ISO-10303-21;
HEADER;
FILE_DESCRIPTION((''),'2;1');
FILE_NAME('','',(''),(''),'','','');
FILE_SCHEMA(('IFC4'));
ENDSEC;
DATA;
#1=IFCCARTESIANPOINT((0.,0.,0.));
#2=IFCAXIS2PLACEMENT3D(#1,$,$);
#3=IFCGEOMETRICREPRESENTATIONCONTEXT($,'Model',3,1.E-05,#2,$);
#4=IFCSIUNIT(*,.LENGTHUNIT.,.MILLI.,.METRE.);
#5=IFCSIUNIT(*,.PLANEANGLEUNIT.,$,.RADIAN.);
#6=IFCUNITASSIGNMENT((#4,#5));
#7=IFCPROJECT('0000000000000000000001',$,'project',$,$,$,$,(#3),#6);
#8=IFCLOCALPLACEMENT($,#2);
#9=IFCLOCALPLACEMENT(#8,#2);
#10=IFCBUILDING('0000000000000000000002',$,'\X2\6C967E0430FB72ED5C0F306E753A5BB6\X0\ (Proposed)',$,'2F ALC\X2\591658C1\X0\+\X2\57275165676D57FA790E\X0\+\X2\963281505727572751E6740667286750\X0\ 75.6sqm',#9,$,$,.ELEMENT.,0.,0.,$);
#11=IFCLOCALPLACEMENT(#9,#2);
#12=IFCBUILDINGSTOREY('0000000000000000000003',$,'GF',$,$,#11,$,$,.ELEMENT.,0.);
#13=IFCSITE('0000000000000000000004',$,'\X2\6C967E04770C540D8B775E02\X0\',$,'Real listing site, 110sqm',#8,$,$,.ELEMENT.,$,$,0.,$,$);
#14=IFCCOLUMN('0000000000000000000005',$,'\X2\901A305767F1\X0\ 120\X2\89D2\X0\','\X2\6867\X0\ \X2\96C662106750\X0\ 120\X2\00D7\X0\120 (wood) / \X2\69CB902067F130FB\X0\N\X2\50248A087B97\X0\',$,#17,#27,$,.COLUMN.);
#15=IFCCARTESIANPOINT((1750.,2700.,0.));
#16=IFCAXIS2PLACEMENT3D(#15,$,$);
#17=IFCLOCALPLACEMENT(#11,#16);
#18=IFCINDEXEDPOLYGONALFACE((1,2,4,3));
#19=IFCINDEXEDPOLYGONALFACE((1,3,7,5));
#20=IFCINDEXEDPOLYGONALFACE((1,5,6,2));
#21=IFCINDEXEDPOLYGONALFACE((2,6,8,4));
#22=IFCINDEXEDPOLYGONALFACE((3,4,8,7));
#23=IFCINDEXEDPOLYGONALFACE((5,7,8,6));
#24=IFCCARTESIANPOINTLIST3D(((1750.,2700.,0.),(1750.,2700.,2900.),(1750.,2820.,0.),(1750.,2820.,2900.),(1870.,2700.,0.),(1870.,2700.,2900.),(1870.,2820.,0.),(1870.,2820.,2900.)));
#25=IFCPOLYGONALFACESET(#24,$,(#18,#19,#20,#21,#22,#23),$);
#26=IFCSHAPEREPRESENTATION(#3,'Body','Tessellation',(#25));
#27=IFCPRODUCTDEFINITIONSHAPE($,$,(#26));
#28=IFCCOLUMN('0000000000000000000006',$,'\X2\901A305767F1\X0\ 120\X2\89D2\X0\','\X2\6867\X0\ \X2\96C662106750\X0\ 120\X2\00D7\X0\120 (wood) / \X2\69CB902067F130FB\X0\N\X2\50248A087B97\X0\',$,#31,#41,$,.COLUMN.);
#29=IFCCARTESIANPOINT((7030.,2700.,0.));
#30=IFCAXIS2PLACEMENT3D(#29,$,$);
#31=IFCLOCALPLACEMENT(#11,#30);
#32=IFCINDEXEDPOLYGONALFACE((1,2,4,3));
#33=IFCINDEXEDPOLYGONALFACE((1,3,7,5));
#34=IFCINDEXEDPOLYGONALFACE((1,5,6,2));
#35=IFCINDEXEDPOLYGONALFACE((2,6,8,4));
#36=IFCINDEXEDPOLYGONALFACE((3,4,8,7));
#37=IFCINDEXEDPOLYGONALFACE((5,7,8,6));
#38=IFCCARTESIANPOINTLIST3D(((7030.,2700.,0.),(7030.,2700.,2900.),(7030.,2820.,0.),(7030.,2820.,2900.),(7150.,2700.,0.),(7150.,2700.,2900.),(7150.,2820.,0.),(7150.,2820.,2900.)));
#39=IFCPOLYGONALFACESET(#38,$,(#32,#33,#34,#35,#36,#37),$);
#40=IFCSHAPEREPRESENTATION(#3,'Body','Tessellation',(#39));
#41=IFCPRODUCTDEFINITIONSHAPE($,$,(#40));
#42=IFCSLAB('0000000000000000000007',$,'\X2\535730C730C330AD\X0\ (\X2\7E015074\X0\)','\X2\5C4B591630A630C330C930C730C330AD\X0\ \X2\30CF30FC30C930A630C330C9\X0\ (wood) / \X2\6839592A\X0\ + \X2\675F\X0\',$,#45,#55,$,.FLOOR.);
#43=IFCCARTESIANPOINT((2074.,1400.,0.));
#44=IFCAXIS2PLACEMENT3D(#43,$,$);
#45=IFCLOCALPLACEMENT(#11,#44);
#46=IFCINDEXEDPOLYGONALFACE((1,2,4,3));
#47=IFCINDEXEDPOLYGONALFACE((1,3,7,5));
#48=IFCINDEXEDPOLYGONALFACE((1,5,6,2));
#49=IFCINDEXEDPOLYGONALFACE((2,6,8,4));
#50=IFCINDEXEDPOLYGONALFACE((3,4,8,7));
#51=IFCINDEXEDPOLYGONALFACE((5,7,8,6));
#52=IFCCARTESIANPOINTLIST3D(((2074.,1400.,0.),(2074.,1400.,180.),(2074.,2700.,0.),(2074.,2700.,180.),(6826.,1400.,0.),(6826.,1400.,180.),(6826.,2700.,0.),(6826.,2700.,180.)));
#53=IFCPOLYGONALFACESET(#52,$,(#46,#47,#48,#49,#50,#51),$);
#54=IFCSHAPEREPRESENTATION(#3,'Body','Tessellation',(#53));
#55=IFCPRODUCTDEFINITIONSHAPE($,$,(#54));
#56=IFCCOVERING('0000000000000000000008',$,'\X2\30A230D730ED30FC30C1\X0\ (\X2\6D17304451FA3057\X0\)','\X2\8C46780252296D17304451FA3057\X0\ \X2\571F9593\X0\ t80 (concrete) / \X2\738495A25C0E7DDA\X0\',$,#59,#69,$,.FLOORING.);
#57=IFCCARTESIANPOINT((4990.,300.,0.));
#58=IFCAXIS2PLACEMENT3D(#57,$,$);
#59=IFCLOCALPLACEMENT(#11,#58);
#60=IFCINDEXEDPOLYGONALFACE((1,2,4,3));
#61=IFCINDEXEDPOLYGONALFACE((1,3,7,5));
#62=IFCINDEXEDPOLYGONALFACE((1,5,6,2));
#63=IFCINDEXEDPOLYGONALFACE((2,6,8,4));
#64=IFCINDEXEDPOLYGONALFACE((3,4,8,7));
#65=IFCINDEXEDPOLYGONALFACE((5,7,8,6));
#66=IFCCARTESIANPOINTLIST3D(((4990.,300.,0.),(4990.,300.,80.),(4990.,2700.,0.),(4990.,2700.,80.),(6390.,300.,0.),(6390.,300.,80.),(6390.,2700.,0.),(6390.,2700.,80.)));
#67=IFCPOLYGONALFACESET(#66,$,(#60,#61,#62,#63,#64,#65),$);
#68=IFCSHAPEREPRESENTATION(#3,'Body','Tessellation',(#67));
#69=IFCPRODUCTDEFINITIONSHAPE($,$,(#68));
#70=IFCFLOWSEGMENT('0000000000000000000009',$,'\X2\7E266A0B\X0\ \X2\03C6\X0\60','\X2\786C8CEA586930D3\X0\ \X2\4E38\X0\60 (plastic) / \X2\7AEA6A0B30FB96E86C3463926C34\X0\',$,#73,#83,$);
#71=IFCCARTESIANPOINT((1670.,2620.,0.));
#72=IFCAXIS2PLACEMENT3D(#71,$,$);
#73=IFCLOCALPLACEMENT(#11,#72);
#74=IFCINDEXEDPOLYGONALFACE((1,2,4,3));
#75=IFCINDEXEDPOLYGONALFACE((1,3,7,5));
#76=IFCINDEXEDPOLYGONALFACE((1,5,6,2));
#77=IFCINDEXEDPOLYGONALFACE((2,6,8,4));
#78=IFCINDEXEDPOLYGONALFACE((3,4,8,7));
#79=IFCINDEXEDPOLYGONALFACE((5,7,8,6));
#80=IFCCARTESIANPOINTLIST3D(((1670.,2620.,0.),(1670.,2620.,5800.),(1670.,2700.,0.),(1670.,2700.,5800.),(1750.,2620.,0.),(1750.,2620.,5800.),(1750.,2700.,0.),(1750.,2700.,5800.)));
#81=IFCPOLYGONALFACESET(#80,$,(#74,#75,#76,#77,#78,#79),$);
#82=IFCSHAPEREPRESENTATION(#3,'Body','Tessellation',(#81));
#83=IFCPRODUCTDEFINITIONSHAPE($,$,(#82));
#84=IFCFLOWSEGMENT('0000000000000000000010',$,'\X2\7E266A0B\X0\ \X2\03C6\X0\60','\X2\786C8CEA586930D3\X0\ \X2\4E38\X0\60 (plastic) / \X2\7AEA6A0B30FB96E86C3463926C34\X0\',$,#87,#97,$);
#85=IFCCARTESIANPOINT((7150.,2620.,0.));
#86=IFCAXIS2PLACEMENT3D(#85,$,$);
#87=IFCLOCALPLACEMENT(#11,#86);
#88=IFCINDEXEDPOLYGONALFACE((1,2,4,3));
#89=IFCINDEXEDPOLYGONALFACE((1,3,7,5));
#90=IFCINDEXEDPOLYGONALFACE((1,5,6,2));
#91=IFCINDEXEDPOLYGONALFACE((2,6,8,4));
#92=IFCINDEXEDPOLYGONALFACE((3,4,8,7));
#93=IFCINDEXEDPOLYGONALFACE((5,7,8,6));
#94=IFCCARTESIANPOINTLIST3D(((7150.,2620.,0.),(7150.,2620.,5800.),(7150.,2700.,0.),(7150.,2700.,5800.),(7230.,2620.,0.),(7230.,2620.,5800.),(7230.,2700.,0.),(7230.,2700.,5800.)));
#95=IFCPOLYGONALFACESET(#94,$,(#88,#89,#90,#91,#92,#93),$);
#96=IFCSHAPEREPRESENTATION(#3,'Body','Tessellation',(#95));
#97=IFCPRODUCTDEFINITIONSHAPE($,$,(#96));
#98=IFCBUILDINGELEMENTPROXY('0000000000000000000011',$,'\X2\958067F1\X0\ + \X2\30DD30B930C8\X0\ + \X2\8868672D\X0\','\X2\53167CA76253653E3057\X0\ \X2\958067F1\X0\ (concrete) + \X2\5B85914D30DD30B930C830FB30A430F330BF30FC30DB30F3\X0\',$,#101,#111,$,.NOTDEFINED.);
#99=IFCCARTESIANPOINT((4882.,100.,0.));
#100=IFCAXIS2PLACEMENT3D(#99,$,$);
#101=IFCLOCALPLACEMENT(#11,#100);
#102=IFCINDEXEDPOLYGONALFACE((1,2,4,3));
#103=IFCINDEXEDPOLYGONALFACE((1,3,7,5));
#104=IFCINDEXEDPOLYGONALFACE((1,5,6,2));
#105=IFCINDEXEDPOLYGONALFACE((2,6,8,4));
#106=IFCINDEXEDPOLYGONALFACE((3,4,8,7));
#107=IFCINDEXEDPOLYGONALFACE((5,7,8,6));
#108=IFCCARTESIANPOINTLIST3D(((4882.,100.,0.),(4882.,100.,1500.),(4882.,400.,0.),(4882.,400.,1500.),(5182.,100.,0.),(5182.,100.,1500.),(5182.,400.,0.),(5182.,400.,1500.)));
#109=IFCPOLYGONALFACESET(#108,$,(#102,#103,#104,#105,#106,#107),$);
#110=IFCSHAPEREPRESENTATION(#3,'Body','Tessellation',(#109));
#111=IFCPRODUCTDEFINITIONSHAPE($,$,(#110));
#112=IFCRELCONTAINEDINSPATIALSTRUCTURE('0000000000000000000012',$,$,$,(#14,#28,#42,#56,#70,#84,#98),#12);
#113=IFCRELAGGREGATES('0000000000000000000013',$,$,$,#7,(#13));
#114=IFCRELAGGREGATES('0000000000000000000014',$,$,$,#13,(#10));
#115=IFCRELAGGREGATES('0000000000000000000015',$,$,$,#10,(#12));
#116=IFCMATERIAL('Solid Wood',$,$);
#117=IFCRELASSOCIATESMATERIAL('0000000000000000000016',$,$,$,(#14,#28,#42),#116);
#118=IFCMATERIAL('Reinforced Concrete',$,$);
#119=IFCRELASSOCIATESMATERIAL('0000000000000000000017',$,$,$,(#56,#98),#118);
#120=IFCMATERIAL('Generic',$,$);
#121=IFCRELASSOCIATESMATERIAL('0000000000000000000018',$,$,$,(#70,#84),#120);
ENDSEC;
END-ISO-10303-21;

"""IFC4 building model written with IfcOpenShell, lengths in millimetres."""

from ifc_helpers import new_model, si_unit, frame, frame_2d, origin, place, context, project, spatial, rectangle, extrude, material, element, save


model = new_model("IFC4")

# Units and contexts
model_context = context("Model", 3, precision=1e-05, world=origin())
ifc_project = project(units=[si_unit("LENGTHUNIT", "METRE", prefix="MILLI"), si_unit("PLANEANGLEUNIT", "RADIAN")], contexts=[model_context])

# Site, building, storey
site_placement = place(None, origin())
site = spatial("IfcSite", under=ifc_project, at=site_placement, Name="沖縄県名護市", ObjectType="Real listing site, 110sqm", CompositionType="ELEMENT", RefElevation=0.0)
building_placement = place(site_placement, origin())
building = spatial("IfcBuilding", under=site, at=building_placement, Name="沖縄・狭小の町家 (Proposed)", ObjectType="2F ALC外壁+圧入杭基礎+防腐圧圧処理木材 75.6sqm", CompositionType="ELEMENT", ElevationOfRefHeight=0.0, ElevationOfTerrain=0.0)
storey_placement = place(building_placement, origin())
storey = spatial("IfcBuildingStorey", under=building, at=storey_placement, Name="GF", CompositionType="ELEMENT", Elevation=0.0)

# Columns
ifc_material_1 = material(Name="Solid Wood")
column_1_placement = place(storey_placement, frame((1750.0, 2700.0, 0.0)))
element("IfcColumn", 1, at=column_1_placement, inside=storey, material=ifc_material_1, Name="通し柱 120角", Description="桧 集成材 120×120 (wood) / 構造柱・N値計算", PredefinedType="COLUMN", context=model_context, shape_type="SweptSolid", body=[
    extrude(rectangle(XDim=120.0, YDim=120.0, at=frame_2d((60.0, 60.0))), frame((1750.0, 2700.0, 0.0)), (0.0, 0.0, 1.0), 2900.0),
])
column_2_placement = place(storey_placement, frame((7030.0, 2700.0, 0.0)))
element("IfcColumn", 2, at=column_2_placement, inside=storey, material=ifc_material_1, Name="通し柱 120角", Description="桧 集成材 120×120 (wood) / 構造柱・N値計算", PredefinedType="COLUMN", context=model_context, shape_type="SweptSolid", body=[
    extrude(rectangle(XDim=120.0, YDim=120.0, at=frame_2d((60.0, 60.0))), frame((7030.0, 2700.0, 0.0)), (0.0, 0.0, 1.0), 2900.0),
])

# Slab
ifc_material_2 = material(Name="Reinforced Concrete")
slab_1_placement = place(storey_placement, frame((2074.0, 1400.0, 0.0)))
element("IfcSlab", 3, at=slab_1_placement, inside=storey, material=ifc_material_1, Name="南デッキ (縁側)", Description="屋外ウッドデッキ ハードウッド (wood) / 根太 + 束", PredefinedType="FLOOR", context=model_context, shape_type="SweptSolid", body=[
    extrude(rectangle(XDim=4752.0, YDim=1300.0, at=frame_2d((2376.0, 650.0))), frame((2074.0, 1400.0, 0.0)), (0.0, 0.0, 1.0), 180.0),
])

# Covering
covering_1_placement = place(storey_placement, frame((4990.0, 300.0, 0.0)))
element("IfcCovering", 4, at=covering_1_placement, inside=storey, material=ifc_material_2, Name="アプローチ (洗い出し)", Description="豆砂利洗い出し 土間 t80 (concrete) / 玄関導線", PredefinedType="FLOORING", context=model_context, shape_type="SweptSolid", body=[
    extrude(rectangle(XDim=1400.0, YDim=2400.0, at=frame_2d((700.0, 1200.0))), frame((4990.0, 300.0, 0.0)), (0.0, 0.0, 1.0), 80.0),
])

# Flow segments
ifc_material_3 = material(Name="Generic")
flow_segment_1_placement = place(storey_placement, frame((1670.0, 2620.0, 0.0)))
element("IfcFlowSegment", 5, at=flow_segment_1_placement, inside=storey, material=ifc_material_3, Name="縦樋 φ60", Description="硬質塩ビ 丸60 (plastic) / 竪樋・雨水排水", context=model_context, shape_type="SweptSolid", body=[
    extrude(rectangle(XDim=80.0, YDim=80.0, at=frame_2d((40.0, 40.0))), frame((1670.0, 2620.0, 0.0)), (0.0, 0.0, 1.0), 5800.0),
])
flow_segment_2_placement = place(storey_placement, frame((7150.0, 2620.0, 0.0)))
element("IfcFlowSegment", 6, at=flow_segment_2_placement, inside=storey, material=ifc_material_3, Name="縦樋 φ60", Description="硬質塩ビ 丸60 (plastic) / 竪樋・雨水排水", context=model_context, shape_type="SweptSolid", body=[
    extrude(rectangle(XDim=80.0, YDim=80.0, at=frame_2d((40.0, 40.0))), frame((7150.0, 2620.0, 0.0)), (0.0, 0.0, 1.0), 5800.0),
])

# Building element proxy
proxy_placement = place(storey_placement, frame((4882.0, 100.0, 0.0)))
element("IfcBuildingElementProxy", 7, at=proxy_placement, inside=storey, material=ifc_material_2, Name="門柱 + ポスト + 表札", Description="化粧打放し 門柱 (concrete) + 宅配ポスト・インターホン", PredefinedType="NOTDEFINED", context=model_context, shape_type="SweptSolid", body=[
    extrude(rectangle(XDim=300.0, YDim=300.0, at=frame_2d((150.0, 150.0))), frame((4882.0, 100.0, 0.0)), (0.0, 0.0, 1.0), 1500.0),
])

save(model, "model.ifc")
